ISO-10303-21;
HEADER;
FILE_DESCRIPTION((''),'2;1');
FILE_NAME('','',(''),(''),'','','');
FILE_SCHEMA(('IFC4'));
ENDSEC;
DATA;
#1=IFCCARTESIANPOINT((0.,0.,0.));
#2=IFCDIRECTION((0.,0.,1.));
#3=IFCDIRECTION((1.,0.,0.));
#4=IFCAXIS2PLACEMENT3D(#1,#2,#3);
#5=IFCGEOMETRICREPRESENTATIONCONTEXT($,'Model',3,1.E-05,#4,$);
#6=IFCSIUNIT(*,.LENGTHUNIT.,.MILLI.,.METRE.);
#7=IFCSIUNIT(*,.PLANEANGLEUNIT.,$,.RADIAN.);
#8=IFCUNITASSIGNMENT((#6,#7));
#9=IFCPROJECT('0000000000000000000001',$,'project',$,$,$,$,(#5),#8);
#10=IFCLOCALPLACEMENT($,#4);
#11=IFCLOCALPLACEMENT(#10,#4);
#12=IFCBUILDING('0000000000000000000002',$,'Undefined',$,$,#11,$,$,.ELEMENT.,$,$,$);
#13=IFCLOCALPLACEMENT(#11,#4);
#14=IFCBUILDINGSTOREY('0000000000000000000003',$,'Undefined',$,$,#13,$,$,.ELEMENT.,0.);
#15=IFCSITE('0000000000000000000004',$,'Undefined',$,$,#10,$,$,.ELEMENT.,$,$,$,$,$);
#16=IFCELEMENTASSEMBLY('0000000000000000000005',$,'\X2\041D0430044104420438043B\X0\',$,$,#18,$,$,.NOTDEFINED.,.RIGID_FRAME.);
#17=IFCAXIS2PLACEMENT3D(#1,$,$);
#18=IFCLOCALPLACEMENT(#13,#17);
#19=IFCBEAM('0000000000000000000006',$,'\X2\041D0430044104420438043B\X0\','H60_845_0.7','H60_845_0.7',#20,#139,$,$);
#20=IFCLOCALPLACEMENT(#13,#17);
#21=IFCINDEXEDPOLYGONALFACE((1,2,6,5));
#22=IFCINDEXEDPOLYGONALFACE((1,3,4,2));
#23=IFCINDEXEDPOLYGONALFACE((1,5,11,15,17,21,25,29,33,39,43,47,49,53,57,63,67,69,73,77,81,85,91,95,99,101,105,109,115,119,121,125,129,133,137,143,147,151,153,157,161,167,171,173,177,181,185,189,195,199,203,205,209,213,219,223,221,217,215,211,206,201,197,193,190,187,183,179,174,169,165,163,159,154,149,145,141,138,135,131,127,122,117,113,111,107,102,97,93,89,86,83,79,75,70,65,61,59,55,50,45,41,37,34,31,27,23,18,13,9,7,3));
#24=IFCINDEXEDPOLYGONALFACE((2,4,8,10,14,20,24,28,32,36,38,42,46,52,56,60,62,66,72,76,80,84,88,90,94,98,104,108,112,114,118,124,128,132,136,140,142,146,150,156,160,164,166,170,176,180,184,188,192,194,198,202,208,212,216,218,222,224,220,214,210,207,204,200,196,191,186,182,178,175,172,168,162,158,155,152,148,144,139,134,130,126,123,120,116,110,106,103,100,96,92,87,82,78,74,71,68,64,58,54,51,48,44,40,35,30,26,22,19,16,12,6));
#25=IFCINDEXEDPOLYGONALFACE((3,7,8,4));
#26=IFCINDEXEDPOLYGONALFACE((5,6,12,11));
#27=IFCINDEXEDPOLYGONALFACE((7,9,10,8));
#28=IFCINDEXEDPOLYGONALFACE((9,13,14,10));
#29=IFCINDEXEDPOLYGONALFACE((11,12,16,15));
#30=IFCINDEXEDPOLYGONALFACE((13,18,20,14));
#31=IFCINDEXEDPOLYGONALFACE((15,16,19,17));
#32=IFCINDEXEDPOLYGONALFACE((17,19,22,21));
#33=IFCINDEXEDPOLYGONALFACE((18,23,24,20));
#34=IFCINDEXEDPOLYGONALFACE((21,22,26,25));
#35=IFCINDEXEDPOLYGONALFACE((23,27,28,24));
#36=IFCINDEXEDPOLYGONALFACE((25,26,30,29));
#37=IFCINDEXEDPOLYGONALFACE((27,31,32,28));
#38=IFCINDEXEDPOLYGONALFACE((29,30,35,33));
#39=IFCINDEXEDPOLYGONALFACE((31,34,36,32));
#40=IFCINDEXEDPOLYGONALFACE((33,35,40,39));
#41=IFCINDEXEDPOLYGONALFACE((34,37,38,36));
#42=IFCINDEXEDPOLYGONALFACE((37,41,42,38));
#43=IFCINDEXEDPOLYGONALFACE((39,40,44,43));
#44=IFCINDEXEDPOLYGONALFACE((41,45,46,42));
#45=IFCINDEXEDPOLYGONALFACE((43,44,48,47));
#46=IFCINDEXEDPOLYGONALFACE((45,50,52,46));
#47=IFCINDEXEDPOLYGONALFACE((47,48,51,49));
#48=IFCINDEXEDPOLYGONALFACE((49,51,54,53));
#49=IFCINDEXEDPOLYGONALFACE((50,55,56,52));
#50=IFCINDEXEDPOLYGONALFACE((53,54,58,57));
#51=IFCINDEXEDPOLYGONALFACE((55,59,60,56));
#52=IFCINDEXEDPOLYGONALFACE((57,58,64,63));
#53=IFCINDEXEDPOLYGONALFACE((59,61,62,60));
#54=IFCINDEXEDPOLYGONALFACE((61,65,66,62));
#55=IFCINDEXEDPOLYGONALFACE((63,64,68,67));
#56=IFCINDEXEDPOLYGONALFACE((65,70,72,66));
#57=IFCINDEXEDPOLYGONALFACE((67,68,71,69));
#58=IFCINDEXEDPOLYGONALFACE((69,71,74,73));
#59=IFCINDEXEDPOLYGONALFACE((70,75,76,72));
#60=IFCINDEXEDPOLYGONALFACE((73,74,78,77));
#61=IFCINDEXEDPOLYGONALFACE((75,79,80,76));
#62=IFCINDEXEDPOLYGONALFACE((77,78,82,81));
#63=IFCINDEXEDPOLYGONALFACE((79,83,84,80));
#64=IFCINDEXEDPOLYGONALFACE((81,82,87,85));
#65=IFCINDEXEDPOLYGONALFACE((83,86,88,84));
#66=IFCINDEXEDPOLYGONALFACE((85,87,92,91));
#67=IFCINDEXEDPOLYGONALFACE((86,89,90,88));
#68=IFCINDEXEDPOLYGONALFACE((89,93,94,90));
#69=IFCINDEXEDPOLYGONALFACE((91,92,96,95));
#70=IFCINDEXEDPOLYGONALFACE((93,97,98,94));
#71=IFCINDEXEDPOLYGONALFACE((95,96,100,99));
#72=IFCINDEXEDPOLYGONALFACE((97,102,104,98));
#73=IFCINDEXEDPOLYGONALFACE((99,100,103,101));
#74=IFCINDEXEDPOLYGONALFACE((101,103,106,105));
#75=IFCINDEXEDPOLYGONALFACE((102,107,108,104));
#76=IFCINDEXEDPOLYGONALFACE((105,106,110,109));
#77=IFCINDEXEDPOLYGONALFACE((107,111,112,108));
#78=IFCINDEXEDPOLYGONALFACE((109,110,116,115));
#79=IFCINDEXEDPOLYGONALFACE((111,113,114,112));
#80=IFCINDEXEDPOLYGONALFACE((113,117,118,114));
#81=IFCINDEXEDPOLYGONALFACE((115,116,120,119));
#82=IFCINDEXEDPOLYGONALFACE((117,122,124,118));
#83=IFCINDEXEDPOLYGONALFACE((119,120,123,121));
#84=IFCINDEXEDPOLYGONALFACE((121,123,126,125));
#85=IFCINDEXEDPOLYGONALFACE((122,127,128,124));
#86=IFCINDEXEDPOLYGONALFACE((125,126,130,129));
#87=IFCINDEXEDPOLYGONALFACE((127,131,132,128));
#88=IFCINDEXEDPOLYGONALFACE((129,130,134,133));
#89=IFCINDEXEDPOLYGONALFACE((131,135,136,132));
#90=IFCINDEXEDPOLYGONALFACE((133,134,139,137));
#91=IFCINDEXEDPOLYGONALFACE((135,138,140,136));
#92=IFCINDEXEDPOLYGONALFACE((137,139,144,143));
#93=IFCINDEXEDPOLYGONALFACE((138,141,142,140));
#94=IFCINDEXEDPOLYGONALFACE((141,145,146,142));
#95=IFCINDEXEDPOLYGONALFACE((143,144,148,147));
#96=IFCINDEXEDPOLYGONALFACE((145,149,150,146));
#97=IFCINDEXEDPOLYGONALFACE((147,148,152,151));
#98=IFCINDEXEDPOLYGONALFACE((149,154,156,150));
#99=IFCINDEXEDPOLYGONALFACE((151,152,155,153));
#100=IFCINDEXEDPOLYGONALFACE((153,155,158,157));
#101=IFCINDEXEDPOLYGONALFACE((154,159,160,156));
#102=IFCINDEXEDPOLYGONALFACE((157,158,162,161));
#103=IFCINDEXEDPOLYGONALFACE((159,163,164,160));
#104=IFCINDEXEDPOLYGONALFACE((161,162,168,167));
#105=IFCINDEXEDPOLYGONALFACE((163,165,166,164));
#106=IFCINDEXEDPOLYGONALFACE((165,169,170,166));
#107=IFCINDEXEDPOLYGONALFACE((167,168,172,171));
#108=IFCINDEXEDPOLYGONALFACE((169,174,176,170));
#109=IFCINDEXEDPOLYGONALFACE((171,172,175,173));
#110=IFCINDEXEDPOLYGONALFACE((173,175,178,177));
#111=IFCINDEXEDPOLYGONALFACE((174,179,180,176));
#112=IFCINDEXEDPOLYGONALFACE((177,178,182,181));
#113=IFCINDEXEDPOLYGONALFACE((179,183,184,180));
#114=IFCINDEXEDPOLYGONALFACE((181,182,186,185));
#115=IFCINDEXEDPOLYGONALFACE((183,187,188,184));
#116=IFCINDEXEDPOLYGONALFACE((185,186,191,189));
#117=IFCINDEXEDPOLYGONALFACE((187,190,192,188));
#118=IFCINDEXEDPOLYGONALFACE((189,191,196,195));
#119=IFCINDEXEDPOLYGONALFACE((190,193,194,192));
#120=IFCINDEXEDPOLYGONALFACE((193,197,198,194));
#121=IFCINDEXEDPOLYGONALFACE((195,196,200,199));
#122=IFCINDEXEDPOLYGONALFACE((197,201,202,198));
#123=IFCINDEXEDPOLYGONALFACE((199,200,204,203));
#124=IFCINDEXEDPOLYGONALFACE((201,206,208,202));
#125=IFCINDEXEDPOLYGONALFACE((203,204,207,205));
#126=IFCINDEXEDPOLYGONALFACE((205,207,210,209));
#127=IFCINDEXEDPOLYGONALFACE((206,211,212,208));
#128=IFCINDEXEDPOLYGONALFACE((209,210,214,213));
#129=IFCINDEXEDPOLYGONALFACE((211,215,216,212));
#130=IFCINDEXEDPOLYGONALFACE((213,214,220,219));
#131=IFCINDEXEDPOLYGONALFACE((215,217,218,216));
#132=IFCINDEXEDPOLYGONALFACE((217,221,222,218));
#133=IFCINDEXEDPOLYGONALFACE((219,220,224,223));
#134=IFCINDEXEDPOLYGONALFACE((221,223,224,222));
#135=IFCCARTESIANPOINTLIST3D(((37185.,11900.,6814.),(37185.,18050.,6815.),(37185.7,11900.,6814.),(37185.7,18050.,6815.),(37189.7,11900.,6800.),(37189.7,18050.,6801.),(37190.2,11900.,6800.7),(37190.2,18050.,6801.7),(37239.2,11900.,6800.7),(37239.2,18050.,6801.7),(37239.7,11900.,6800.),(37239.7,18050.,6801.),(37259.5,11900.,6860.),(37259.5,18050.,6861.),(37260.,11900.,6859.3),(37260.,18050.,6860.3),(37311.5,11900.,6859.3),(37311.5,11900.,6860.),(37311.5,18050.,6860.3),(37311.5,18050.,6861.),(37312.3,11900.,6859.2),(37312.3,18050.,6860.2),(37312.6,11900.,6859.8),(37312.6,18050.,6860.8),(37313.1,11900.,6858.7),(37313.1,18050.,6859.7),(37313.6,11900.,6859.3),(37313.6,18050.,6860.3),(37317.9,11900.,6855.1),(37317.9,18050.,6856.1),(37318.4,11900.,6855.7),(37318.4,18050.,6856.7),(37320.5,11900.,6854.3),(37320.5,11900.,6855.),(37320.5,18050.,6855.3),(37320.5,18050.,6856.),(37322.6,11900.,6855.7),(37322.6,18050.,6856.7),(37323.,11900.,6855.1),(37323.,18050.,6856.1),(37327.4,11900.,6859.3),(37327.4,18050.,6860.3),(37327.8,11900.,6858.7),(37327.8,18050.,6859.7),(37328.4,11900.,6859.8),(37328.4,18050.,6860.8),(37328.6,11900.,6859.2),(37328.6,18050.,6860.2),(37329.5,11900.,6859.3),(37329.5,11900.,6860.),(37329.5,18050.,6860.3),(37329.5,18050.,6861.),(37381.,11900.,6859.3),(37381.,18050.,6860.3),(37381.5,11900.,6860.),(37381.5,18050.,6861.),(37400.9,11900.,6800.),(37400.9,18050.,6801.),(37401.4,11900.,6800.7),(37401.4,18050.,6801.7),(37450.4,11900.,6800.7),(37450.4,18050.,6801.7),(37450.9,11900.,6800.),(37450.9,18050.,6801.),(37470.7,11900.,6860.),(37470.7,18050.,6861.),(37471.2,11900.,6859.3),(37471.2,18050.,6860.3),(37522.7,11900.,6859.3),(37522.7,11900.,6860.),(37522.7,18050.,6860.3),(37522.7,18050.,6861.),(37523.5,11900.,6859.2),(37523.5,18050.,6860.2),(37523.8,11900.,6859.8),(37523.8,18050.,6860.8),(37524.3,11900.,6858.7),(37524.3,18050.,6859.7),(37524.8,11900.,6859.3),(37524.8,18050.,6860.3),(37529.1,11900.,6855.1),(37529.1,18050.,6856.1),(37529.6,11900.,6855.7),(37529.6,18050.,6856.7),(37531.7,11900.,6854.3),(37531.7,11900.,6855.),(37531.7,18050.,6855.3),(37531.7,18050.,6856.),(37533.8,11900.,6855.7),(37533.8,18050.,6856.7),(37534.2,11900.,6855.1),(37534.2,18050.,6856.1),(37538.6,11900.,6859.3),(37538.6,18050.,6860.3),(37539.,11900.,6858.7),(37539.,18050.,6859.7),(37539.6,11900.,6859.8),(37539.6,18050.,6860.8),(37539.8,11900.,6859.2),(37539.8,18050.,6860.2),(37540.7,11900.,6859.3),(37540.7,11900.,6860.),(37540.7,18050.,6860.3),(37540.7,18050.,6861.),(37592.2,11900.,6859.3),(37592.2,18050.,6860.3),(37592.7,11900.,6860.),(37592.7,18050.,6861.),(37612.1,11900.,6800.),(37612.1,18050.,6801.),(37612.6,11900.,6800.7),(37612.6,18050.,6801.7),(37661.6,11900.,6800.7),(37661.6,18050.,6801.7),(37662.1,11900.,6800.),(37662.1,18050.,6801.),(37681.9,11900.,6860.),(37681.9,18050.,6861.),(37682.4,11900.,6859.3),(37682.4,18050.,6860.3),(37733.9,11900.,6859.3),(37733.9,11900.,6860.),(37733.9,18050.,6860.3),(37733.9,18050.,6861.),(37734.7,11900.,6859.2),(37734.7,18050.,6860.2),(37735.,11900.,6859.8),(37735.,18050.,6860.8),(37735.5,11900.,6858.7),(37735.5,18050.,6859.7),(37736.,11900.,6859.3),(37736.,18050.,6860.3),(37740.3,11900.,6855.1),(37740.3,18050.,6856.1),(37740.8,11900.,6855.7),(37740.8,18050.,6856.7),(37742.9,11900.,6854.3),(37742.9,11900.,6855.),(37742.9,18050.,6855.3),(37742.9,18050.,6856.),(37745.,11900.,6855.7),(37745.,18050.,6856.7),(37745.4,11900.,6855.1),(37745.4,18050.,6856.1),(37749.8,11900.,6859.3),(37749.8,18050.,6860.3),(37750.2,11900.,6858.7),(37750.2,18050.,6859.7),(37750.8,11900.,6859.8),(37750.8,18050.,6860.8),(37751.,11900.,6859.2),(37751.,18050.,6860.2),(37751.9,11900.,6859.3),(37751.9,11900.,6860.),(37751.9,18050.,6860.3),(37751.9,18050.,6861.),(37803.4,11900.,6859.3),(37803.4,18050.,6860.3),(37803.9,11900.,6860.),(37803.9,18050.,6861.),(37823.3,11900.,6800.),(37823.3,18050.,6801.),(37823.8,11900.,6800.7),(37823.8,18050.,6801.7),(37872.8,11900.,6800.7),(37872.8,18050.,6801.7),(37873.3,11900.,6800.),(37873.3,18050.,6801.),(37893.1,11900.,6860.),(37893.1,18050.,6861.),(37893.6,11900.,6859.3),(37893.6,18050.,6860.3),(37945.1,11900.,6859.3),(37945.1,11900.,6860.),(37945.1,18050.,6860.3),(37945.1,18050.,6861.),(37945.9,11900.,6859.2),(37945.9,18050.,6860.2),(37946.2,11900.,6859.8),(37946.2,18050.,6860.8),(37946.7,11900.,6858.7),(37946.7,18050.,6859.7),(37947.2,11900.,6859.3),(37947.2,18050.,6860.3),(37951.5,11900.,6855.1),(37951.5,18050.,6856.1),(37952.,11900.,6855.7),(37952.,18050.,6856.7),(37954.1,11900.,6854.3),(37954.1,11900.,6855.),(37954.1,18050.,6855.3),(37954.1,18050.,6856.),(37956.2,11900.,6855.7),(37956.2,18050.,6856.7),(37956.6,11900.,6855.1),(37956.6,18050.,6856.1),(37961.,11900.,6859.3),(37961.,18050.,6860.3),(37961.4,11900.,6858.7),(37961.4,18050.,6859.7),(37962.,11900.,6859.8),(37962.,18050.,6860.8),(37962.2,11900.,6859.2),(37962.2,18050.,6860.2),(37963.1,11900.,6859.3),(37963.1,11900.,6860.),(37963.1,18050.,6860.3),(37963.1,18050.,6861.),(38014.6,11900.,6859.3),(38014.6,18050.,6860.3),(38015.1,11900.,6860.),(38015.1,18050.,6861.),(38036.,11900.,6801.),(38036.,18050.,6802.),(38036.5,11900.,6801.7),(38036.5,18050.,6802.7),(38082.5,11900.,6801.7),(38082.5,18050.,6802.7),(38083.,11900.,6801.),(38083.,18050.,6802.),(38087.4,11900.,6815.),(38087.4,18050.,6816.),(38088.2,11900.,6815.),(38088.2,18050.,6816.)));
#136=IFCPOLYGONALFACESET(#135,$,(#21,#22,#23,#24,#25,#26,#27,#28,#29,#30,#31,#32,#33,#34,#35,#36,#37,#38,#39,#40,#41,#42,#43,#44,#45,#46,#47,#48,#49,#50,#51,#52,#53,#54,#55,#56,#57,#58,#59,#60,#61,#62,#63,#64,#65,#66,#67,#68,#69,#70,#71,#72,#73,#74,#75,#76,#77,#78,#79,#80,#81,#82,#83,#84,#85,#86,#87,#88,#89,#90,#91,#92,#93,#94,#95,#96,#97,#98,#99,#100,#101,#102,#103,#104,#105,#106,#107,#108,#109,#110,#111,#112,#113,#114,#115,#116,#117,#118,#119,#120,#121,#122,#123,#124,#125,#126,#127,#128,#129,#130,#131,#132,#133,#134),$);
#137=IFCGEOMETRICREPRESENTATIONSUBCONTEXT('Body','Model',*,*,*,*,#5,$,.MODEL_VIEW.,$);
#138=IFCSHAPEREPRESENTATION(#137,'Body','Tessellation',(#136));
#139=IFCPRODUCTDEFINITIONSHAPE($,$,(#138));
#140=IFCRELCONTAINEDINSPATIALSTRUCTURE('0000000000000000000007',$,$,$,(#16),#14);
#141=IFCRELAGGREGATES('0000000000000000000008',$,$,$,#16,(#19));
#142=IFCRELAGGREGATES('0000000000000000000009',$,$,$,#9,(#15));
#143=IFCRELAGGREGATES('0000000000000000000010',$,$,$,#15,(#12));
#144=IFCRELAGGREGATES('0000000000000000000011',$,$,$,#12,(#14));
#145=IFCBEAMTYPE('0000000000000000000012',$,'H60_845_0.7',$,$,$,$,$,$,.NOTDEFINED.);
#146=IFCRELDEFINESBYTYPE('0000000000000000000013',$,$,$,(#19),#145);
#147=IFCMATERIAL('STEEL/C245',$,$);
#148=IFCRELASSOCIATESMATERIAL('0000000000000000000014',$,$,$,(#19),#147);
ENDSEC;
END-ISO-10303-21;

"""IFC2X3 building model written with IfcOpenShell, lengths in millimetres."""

from ifc_helpers import new_model, si_unit, frame, origin_with_axes, place, context, subcontext, project, spatial, polyline, outline, extrude, material, type_object, element, aggregate, save


model = new_model("IFC2X3")

# Units and contexts
model_context = context("Model", 3, precision=1e-05, world=origin_with_axes())
body_context = subcontext(model_context, "Body", "Model", "MODEL_VIEW")
ifc_project = project(units=[si_unit("LENGTHUNIT", "METRE", prefix="MILLI"), si_unit("PLANEANGLEUNIT", "RADIAN")], contexts=[model_context])

# Site, building, storey
site_placement = place(None, origin_with_axes())
site = spatial("IfcSite", under=ifc_project, at=site_placement, Name="Undefined", CompositionType="ELEMENT")
building_placement = place(site_placement, origin_with_axes())
building = spatial("IfcBuilding", under=site, at=building_placement, Name="Undefined", CompositionType="ELEMENT")
storey_placement = place(building_placement, origin_with_axes())
storey = spatial("IfcBuildingStorey", under=building, at=storey_placement, Name="Undefined", CompositionType="ELEMENT", Elevation=0.0)

# Element assembly, beam
ifc_material_1 = material(Name="STEEL/C245")
beam_type_1 = type_object("IfcBeamType", Name="H60_845_0.7", PredefinedType="NOTDEFINED")
assembly_1_placement = place(storey_placement, origin_with_axes())
assembly_1 = element("IfcElementAssembly", 1, at=assembly_1_placement, inside=storey, Name="Настил", AssemblyPlace="NOTDEFINED", PredefinedType="RIGID_FRAME")
beam_1_placement = place(assembly_1_placement, frame((37636.2, 18050.0, 6831.0), z_axis=(0.0, -0.000163, 1.0), x_axis=(0.0, -1.0, -0.000163)))
beam_1 = element("IfcBeam", 2, at=beam_1_placement, type_object=beam_type_1, material=ifc_material_1, Name="Настил", Description="H60_845_0.7", ObjectType="H60_845_0.7", context=body_context, shape_type="SweptSolid", body=[
    extrude(outline(polyline([(-399.8, -29.0), (-446.8, -29.0), (-452.0, -15.0), (-451.2, -15.0), (-446.3, -28.3), (-400.3, -28.3), (-378.9, 30.0), (-326.9, 30.0), (-325.7, 29.8), (-324.7, 29.3), (-320.0, 25.7), (-317.9, 25.0), (-315.8, 25.7), (-311.0, 29.3), (-310.0, 29.8), (-308.9, 30.0), (-256.9, 30.0), (-236.6, -29.3), (-187.6, -29.3), (-167.7, 30.0), (-115.7, 30.0), (-114.5, 29.8), (-113.5, 29.3), (-108.8, 25.7), (-106.7, 25.0), (-104.6, 25.7), (-99.7, 29.3), (-98.8, 29.8), (-97.7, 30.0), (-45.7, 30.0), (-25.4, -29.3), (23.6, -29.3), (43.5, 30.0), (95.5, 30.0), (96.7, 29.8), (97.7, 29.3), (102.4, 25.7), (104.5, 25.0), (106.6, 25.7), (111.4, 29.3), (112.4, 29.8), (113.5, 30.0), (165.5, 30.0), (185.8, -29.3), (234.8, -29.3), (254.7, 30.0), (306.7, 30.0), (307.9, 29.8), (308.9, 29.3), (313.6, 25.7), (315.7, 25.0), (317.8, 25.7), (322.6, 29.3), (323.6, 29.8), (324.7, 30.0), (376.7, 30.0), (397.0, -29.3), (446.0, -29.3), (450.5, -16.0), (451.2, -16.0), (446.5, -30.0), (396.5, -30.0), (376.2, 29.3), (324.7, 29.3), (323.9, 29.2), (323.1, 28.7), (318.3, 25.1), (315.7, 24.3), (313.2, 25.1), (308.4, 28.7), (307.6, 29.2), (306.7, 29.3), (255.2, 29.3), (235.3, -30.0), (185.3, -30.0), (165.0, 29.3), (113.5, 29.3), (112.7, 29.2), (111.9, 28.7), (107.1, 25.1), (104.5, 24.3), (102.0, 25.1), (97.2, 28.7), (96.4, 29.2), (95.5, 29.3), (44.0, 29.3), (24.1, -30.0), (-25.9, -30.0), (-46.2, 29.3), (-97.7, 29.3), (-98.5, 29.2), (-99.3, 28.7), (-104.1, 25.1), (-106.7, 24.3), (-109.2, 25.1), (-114.0, 28.7), (-114.8, 29.2), (-115.7, 29.3), (-167.2, 29.3), (-187.1, -30.0), (-237.1, -30.0), (-257.4, 29.3), (-308.9, 29.3), (-309.7, 29.2), (-310.5, 28.7), (-315.3, 25.1), (-317.9, 24.3), (-320.4, 25.1), (-325.2, 28.7), (-326.0, 29.2), (-326.9, 29.3), (-378.4, 29.3), (-399.8, -29.0)])), frame((6150.0, 0.0, 0.0), z_axis=(-1.0, 0.0, 0.0), x_axis=(0.0, -1.0, 0.0)), (0.0, 0.0, 1.0), 6150.0),
])
aggregate(assembly_1, [beam_1])

save(model, "model.ifc")
